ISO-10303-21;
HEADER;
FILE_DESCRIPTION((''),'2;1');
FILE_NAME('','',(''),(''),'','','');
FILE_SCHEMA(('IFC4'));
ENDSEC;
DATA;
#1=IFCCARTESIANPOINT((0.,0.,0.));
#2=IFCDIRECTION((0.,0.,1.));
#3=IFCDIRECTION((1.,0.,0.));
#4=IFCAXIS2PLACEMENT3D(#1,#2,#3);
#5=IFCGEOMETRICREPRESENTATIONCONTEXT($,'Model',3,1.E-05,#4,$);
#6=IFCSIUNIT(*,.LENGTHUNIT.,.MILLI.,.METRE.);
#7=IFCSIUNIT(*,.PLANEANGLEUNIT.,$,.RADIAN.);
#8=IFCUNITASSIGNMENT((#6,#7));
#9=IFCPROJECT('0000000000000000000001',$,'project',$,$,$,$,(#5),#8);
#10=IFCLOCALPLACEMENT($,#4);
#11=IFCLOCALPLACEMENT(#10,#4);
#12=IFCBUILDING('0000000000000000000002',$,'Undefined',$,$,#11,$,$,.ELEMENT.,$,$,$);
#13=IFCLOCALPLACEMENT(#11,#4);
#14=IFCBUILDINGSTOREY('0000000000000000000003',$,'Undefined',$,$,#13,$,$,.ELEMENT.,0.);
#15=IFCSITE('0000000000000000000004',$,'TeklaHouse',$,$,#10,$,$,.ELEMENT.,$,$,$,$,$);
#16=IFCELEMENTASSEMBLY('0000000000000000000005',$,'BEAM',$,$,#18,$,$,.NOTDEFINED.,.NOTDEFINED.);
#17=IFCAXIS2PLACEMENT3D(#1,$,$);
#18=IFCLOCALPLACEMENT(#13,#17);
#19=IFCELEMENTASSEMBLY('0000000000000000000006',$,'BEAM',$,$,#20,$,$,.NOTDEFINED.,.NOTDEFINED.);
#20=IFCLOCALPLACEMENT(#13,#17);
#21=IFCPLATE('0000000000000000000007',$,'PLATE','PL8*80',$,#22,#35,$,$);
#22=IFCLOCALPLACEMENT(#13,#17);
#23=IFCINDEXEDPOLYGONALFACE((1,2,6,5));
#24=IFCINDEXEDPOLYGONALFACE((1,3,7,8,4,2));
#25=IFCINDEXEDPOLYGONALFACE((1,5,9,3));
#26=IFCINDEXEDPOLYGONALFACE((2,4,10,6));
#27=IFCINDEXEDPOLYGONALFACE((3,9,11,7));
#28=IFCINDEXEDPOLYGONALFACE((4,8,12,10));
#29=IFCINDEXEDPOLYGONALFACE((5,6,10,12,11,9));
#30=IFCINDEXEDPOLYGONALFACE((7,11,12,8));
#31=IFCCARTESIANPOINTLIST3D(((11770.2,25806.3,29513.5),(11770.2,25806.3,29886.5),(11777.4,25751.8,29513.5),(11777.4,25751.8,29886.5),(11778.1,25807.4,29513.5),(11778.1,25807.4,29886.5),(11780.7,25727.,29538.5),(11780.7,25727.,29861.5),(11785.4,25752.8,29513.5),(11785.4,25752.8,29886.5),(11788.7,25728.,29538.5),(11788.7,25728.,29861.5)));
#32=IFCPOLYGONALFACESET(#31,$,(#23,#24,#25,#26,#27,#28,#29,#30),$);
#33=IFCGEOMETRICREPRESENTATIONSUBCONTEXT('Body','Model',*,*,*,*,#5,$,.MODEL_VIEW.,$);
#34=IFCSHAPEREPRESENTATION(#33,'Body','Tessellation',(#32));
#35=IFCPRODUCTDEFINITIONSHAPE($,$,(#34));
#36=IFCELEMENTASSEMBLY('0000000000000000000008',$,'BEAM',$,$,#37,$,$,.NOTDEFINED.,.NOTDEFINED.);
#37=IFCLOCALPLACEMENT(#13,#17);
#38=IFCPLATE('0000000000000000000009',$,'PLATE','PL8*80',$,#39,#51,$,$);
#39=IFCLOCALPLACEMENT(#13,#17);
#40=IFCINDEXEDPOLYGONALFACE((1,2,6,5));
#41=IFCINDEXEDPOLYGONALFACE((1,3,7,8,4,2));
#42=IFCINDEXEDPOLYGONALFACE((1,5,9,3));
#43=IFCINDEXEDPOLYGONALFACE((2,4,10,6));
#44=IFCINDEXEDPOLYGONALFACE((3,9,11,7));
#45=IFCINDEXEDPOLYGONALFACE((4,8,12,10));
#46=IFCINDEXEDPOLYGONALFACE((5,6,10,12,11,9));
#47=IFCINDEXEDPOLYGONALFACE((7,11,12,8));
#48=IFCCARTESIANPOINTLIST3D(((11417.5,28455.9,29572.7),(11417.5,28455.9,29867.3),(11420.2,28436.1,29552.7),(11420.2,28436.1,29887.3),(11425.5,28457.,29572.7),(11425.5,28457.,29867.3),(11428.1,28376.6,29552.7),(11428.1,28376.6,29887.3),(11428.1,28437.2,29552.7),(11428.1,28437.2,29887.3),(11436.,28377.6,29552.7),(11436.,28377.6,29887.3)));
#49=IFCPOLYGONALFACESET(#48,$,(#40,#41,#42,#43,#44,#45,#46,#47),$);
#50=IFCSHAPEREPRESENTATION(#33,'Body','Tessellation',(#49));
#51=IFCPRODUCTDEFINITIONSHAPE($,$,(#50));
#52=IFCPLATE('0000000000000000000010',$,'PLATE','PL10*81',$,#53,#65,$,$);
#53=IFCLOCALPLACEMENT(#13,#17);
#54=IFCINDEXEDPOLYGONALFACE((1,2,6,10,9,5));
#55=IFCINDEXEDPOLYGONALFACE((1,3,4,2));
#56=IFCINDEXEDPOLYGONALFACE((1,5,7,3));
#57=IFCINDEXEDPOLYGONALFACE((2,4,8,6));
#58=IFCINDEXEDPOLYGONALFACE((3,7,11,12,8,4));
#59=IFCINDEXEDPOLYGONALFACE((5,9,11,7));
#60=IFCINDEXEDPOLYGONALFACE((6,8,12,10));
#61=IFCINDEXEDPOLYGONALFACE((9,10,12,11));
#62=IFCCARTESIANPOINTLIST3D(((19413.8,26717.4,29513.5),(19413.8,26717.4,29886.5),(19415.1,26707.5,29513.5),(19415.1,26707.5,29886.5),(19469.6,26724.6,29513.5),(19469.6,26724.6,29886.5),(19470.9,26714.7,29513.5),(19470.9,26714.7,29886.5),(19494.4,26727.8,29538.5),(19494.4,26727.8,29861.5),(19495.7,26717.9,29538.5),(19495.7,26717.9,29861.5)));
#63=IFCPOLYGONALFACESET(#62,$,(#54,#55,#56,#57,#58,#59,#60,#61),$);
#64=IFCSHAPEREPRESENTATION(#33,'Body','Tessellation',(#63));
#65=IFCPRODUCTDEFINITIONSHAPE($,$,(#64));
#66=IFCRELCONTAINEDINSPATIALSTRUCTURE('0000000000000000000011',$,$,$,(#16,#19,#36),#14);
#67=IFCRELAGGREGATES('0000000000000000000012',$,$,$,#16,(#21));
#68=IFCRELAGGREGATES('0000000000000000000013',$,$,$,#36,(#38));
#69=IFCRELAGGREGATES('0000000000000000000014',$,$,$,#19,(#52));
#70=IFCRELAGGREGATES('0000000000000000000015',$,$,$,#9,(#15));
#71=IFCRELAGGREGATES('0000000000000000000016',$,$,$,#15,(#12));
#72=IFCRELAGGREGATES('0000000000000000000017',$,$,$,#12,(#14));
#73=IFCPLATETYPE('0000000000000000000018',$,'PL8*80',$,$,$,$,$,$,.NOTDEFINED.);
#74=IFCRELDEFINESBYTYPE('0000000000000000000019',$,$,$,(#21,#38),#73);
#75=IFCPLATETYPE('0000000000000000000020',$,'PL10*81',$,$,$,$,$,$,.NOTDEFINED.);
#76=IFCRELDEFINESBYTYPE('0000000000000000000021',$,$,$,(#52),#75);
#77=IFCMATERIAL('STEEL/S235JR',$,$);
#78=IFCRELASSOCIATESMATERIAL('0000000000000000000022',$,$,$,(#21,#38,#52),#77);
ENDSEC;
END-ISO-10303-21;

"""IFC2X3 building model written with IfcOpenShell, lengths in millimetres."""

from ifc_helpers import new_model, si_unit, frame, origin_with_axes, place, context, subcontext, project, spatial, polyline, outline, extrude, material, type_object, element, aggregate, save


model = new_model("IFC2X3")

# Units and contexts
model_context = context("Model", 3, precision=1e-05, world=origin_with_axes())
body_context = subcontext(model_context, "Body", "Model", "MODEL_VIEW")
ifc_project = project(units=[si_unit("LENGTHUNIT", "METRE", prefix="MILLI"), si_unit("PLANEANGLEUNIT", "RADIAN")], contexts=[model_context])

# Site, building, storey
site_placement = place(None, origin_with_axes())
site = spatial("IfcSite", under=ifc_project, at=site_placement, Name="TeklaHouse", CompositionType="ELEMENT")
building_placement = place(site_placement, origin_with_axes())
building = spatial("IfcBuilding", under=site, at=building_placement, Name="Undefined", CompositionType="ELEMENT")
storey_placement = place(building_placement, origin_with_axes())
storey = spatial("IfcBuildingStorey", under=building, at=storey_placement, Name="Undefined", CompositionType="ELEMENT", Elevation=0.0)

# Shared definitions
ifc_material_1 = material(Name="STEEL/S235JR")

# Element assembly
assembly_1_placement = place(storey_placement, origin_with_axes())
assembly_1 = element("IfcElementAssembly", 1, at=assembly_1_placement, inside=storey, Name="BEAM", AssemblyPlace="NOTDEFINED", PredefinedType="NOTDEFINED")

# Element assembly
assembly_2_placement = place(storey_placement, origin_with_axes())
assembly_2 = element("IfcElementAssembly", 2, at=assembly_2_placement, inside=storey, Name="BEAM", AssemblyPlace="NOTDEFINED", PredefinedType="NOTDEFINED")

# Plate
plate_type_1 = type_object("IfcPlateType", Name="PL8*80", PredefinedType="NOTDEFINED")
plate_1_placement = place(assembly_1_placement, frame((11784.7, 25727.5, 29513.5), z_axis=(0.991216, 0.132256, 0.0), x_axis=(-0.132256, 0.991216, 0.0)))
plate_1 = element("IfcPlate", 3, at=plate_1_placement, type_object=plate_type_1, material=ifc_material_1, Name="PLATE", Description="PL8*80", context=body_context, shape_type="SweptSolid", body=[
    extrude(outline(polyline([(0.0, 25.0), (25.0, 0.0), (80.0, 0.0), (80.0, 373.0), (25.0, 373.0), (0.0, 348.0), (0.0, 25.0)])), frame((0.0, 0.0, -4.0), z_axis=(0.0, 0.0, 1.0), x_axis=(1.0, 0.0, 0.0)), (0.0, 0.0, 1.0), 8.0),
])
aggregate(assembly_1, [plate_1])

# Element assembly, plate
assembly_3_placement = place(storey_placement, origin_with_axes())
assembly_3 = element("IfcElementAssembly", 4, at=assembly_3_placement, inside=storey, Name="BEAM", AssemblyPlace="NOTDEFINED", PredefinedType="NOTDEFINED")
plate_2_placement = place(assembly_3_placement, frame((11421.5, 28456.5, 29552.7), z_axis=(-0.991216, -0.132256, 0.0), x_axis=(0.132256, -0.991216, 0.0)))
plate_2 = element("IfcPlate", 5, at=plate_2_placement, type_object=plate_type_1, material=ifc_material_1, Name="PLATE", Description="PL8*80", context=body_context, shape_type="SweptSolid", body=[
    extrude(outline(polyline([(0.0, 20.0), (20.0, 0.0), (80.1, 0.0), (80.1, 334.6), (20.0, 334.6), (0.0, 314.6), (0.0, 20.0)])), frame((0.0, 0.0, -4.0), z_axis=(0.0, 0.0, 1.0), x_axis=(1.0, 0.0, 0.0)), (0.0, 0.0, 1.0), 8.0),
])
aggregate(assembly_3, [plate_2])

# Plate
plate_type_2 = type_object("IfcPlateType", Name="PL10*81", PredefinedType="NOTDEFINED")
plate_3_placement = place(assembly_2_placement, frame((19495.1, 26722.9, 29513.5), z_axis=(-0.128673, 0.991687, 0.0), x_axis=(-0.991687, -0.128673, 0.0)))
plate_3 = element("IfcPlate", 6, at=plate_3_placement, type_object=plate_type_2, material=ifc_material_1, Name="PLATE", Description="PL10*81", context=body_context, shape_type="SweptSolid", body=[
    extrude(outline(polyline([(0.0, 25.0), (25.0, 0.0), (81.3, 0.0), (81.3, 373.0), (25.0, 373.0), (0.0, 348.0), (0.0, 25.0)])), frame((0.0, 0.0, -5.0), z_axis=(0.0, 0.0, 1.0), x_axis=(1.0, 0.0, 0.0)), (0.0, 0.0, 1.0), 10.0),
])
aggregate(assembly_2, [plate_3])

save(model, "model.ifc")
